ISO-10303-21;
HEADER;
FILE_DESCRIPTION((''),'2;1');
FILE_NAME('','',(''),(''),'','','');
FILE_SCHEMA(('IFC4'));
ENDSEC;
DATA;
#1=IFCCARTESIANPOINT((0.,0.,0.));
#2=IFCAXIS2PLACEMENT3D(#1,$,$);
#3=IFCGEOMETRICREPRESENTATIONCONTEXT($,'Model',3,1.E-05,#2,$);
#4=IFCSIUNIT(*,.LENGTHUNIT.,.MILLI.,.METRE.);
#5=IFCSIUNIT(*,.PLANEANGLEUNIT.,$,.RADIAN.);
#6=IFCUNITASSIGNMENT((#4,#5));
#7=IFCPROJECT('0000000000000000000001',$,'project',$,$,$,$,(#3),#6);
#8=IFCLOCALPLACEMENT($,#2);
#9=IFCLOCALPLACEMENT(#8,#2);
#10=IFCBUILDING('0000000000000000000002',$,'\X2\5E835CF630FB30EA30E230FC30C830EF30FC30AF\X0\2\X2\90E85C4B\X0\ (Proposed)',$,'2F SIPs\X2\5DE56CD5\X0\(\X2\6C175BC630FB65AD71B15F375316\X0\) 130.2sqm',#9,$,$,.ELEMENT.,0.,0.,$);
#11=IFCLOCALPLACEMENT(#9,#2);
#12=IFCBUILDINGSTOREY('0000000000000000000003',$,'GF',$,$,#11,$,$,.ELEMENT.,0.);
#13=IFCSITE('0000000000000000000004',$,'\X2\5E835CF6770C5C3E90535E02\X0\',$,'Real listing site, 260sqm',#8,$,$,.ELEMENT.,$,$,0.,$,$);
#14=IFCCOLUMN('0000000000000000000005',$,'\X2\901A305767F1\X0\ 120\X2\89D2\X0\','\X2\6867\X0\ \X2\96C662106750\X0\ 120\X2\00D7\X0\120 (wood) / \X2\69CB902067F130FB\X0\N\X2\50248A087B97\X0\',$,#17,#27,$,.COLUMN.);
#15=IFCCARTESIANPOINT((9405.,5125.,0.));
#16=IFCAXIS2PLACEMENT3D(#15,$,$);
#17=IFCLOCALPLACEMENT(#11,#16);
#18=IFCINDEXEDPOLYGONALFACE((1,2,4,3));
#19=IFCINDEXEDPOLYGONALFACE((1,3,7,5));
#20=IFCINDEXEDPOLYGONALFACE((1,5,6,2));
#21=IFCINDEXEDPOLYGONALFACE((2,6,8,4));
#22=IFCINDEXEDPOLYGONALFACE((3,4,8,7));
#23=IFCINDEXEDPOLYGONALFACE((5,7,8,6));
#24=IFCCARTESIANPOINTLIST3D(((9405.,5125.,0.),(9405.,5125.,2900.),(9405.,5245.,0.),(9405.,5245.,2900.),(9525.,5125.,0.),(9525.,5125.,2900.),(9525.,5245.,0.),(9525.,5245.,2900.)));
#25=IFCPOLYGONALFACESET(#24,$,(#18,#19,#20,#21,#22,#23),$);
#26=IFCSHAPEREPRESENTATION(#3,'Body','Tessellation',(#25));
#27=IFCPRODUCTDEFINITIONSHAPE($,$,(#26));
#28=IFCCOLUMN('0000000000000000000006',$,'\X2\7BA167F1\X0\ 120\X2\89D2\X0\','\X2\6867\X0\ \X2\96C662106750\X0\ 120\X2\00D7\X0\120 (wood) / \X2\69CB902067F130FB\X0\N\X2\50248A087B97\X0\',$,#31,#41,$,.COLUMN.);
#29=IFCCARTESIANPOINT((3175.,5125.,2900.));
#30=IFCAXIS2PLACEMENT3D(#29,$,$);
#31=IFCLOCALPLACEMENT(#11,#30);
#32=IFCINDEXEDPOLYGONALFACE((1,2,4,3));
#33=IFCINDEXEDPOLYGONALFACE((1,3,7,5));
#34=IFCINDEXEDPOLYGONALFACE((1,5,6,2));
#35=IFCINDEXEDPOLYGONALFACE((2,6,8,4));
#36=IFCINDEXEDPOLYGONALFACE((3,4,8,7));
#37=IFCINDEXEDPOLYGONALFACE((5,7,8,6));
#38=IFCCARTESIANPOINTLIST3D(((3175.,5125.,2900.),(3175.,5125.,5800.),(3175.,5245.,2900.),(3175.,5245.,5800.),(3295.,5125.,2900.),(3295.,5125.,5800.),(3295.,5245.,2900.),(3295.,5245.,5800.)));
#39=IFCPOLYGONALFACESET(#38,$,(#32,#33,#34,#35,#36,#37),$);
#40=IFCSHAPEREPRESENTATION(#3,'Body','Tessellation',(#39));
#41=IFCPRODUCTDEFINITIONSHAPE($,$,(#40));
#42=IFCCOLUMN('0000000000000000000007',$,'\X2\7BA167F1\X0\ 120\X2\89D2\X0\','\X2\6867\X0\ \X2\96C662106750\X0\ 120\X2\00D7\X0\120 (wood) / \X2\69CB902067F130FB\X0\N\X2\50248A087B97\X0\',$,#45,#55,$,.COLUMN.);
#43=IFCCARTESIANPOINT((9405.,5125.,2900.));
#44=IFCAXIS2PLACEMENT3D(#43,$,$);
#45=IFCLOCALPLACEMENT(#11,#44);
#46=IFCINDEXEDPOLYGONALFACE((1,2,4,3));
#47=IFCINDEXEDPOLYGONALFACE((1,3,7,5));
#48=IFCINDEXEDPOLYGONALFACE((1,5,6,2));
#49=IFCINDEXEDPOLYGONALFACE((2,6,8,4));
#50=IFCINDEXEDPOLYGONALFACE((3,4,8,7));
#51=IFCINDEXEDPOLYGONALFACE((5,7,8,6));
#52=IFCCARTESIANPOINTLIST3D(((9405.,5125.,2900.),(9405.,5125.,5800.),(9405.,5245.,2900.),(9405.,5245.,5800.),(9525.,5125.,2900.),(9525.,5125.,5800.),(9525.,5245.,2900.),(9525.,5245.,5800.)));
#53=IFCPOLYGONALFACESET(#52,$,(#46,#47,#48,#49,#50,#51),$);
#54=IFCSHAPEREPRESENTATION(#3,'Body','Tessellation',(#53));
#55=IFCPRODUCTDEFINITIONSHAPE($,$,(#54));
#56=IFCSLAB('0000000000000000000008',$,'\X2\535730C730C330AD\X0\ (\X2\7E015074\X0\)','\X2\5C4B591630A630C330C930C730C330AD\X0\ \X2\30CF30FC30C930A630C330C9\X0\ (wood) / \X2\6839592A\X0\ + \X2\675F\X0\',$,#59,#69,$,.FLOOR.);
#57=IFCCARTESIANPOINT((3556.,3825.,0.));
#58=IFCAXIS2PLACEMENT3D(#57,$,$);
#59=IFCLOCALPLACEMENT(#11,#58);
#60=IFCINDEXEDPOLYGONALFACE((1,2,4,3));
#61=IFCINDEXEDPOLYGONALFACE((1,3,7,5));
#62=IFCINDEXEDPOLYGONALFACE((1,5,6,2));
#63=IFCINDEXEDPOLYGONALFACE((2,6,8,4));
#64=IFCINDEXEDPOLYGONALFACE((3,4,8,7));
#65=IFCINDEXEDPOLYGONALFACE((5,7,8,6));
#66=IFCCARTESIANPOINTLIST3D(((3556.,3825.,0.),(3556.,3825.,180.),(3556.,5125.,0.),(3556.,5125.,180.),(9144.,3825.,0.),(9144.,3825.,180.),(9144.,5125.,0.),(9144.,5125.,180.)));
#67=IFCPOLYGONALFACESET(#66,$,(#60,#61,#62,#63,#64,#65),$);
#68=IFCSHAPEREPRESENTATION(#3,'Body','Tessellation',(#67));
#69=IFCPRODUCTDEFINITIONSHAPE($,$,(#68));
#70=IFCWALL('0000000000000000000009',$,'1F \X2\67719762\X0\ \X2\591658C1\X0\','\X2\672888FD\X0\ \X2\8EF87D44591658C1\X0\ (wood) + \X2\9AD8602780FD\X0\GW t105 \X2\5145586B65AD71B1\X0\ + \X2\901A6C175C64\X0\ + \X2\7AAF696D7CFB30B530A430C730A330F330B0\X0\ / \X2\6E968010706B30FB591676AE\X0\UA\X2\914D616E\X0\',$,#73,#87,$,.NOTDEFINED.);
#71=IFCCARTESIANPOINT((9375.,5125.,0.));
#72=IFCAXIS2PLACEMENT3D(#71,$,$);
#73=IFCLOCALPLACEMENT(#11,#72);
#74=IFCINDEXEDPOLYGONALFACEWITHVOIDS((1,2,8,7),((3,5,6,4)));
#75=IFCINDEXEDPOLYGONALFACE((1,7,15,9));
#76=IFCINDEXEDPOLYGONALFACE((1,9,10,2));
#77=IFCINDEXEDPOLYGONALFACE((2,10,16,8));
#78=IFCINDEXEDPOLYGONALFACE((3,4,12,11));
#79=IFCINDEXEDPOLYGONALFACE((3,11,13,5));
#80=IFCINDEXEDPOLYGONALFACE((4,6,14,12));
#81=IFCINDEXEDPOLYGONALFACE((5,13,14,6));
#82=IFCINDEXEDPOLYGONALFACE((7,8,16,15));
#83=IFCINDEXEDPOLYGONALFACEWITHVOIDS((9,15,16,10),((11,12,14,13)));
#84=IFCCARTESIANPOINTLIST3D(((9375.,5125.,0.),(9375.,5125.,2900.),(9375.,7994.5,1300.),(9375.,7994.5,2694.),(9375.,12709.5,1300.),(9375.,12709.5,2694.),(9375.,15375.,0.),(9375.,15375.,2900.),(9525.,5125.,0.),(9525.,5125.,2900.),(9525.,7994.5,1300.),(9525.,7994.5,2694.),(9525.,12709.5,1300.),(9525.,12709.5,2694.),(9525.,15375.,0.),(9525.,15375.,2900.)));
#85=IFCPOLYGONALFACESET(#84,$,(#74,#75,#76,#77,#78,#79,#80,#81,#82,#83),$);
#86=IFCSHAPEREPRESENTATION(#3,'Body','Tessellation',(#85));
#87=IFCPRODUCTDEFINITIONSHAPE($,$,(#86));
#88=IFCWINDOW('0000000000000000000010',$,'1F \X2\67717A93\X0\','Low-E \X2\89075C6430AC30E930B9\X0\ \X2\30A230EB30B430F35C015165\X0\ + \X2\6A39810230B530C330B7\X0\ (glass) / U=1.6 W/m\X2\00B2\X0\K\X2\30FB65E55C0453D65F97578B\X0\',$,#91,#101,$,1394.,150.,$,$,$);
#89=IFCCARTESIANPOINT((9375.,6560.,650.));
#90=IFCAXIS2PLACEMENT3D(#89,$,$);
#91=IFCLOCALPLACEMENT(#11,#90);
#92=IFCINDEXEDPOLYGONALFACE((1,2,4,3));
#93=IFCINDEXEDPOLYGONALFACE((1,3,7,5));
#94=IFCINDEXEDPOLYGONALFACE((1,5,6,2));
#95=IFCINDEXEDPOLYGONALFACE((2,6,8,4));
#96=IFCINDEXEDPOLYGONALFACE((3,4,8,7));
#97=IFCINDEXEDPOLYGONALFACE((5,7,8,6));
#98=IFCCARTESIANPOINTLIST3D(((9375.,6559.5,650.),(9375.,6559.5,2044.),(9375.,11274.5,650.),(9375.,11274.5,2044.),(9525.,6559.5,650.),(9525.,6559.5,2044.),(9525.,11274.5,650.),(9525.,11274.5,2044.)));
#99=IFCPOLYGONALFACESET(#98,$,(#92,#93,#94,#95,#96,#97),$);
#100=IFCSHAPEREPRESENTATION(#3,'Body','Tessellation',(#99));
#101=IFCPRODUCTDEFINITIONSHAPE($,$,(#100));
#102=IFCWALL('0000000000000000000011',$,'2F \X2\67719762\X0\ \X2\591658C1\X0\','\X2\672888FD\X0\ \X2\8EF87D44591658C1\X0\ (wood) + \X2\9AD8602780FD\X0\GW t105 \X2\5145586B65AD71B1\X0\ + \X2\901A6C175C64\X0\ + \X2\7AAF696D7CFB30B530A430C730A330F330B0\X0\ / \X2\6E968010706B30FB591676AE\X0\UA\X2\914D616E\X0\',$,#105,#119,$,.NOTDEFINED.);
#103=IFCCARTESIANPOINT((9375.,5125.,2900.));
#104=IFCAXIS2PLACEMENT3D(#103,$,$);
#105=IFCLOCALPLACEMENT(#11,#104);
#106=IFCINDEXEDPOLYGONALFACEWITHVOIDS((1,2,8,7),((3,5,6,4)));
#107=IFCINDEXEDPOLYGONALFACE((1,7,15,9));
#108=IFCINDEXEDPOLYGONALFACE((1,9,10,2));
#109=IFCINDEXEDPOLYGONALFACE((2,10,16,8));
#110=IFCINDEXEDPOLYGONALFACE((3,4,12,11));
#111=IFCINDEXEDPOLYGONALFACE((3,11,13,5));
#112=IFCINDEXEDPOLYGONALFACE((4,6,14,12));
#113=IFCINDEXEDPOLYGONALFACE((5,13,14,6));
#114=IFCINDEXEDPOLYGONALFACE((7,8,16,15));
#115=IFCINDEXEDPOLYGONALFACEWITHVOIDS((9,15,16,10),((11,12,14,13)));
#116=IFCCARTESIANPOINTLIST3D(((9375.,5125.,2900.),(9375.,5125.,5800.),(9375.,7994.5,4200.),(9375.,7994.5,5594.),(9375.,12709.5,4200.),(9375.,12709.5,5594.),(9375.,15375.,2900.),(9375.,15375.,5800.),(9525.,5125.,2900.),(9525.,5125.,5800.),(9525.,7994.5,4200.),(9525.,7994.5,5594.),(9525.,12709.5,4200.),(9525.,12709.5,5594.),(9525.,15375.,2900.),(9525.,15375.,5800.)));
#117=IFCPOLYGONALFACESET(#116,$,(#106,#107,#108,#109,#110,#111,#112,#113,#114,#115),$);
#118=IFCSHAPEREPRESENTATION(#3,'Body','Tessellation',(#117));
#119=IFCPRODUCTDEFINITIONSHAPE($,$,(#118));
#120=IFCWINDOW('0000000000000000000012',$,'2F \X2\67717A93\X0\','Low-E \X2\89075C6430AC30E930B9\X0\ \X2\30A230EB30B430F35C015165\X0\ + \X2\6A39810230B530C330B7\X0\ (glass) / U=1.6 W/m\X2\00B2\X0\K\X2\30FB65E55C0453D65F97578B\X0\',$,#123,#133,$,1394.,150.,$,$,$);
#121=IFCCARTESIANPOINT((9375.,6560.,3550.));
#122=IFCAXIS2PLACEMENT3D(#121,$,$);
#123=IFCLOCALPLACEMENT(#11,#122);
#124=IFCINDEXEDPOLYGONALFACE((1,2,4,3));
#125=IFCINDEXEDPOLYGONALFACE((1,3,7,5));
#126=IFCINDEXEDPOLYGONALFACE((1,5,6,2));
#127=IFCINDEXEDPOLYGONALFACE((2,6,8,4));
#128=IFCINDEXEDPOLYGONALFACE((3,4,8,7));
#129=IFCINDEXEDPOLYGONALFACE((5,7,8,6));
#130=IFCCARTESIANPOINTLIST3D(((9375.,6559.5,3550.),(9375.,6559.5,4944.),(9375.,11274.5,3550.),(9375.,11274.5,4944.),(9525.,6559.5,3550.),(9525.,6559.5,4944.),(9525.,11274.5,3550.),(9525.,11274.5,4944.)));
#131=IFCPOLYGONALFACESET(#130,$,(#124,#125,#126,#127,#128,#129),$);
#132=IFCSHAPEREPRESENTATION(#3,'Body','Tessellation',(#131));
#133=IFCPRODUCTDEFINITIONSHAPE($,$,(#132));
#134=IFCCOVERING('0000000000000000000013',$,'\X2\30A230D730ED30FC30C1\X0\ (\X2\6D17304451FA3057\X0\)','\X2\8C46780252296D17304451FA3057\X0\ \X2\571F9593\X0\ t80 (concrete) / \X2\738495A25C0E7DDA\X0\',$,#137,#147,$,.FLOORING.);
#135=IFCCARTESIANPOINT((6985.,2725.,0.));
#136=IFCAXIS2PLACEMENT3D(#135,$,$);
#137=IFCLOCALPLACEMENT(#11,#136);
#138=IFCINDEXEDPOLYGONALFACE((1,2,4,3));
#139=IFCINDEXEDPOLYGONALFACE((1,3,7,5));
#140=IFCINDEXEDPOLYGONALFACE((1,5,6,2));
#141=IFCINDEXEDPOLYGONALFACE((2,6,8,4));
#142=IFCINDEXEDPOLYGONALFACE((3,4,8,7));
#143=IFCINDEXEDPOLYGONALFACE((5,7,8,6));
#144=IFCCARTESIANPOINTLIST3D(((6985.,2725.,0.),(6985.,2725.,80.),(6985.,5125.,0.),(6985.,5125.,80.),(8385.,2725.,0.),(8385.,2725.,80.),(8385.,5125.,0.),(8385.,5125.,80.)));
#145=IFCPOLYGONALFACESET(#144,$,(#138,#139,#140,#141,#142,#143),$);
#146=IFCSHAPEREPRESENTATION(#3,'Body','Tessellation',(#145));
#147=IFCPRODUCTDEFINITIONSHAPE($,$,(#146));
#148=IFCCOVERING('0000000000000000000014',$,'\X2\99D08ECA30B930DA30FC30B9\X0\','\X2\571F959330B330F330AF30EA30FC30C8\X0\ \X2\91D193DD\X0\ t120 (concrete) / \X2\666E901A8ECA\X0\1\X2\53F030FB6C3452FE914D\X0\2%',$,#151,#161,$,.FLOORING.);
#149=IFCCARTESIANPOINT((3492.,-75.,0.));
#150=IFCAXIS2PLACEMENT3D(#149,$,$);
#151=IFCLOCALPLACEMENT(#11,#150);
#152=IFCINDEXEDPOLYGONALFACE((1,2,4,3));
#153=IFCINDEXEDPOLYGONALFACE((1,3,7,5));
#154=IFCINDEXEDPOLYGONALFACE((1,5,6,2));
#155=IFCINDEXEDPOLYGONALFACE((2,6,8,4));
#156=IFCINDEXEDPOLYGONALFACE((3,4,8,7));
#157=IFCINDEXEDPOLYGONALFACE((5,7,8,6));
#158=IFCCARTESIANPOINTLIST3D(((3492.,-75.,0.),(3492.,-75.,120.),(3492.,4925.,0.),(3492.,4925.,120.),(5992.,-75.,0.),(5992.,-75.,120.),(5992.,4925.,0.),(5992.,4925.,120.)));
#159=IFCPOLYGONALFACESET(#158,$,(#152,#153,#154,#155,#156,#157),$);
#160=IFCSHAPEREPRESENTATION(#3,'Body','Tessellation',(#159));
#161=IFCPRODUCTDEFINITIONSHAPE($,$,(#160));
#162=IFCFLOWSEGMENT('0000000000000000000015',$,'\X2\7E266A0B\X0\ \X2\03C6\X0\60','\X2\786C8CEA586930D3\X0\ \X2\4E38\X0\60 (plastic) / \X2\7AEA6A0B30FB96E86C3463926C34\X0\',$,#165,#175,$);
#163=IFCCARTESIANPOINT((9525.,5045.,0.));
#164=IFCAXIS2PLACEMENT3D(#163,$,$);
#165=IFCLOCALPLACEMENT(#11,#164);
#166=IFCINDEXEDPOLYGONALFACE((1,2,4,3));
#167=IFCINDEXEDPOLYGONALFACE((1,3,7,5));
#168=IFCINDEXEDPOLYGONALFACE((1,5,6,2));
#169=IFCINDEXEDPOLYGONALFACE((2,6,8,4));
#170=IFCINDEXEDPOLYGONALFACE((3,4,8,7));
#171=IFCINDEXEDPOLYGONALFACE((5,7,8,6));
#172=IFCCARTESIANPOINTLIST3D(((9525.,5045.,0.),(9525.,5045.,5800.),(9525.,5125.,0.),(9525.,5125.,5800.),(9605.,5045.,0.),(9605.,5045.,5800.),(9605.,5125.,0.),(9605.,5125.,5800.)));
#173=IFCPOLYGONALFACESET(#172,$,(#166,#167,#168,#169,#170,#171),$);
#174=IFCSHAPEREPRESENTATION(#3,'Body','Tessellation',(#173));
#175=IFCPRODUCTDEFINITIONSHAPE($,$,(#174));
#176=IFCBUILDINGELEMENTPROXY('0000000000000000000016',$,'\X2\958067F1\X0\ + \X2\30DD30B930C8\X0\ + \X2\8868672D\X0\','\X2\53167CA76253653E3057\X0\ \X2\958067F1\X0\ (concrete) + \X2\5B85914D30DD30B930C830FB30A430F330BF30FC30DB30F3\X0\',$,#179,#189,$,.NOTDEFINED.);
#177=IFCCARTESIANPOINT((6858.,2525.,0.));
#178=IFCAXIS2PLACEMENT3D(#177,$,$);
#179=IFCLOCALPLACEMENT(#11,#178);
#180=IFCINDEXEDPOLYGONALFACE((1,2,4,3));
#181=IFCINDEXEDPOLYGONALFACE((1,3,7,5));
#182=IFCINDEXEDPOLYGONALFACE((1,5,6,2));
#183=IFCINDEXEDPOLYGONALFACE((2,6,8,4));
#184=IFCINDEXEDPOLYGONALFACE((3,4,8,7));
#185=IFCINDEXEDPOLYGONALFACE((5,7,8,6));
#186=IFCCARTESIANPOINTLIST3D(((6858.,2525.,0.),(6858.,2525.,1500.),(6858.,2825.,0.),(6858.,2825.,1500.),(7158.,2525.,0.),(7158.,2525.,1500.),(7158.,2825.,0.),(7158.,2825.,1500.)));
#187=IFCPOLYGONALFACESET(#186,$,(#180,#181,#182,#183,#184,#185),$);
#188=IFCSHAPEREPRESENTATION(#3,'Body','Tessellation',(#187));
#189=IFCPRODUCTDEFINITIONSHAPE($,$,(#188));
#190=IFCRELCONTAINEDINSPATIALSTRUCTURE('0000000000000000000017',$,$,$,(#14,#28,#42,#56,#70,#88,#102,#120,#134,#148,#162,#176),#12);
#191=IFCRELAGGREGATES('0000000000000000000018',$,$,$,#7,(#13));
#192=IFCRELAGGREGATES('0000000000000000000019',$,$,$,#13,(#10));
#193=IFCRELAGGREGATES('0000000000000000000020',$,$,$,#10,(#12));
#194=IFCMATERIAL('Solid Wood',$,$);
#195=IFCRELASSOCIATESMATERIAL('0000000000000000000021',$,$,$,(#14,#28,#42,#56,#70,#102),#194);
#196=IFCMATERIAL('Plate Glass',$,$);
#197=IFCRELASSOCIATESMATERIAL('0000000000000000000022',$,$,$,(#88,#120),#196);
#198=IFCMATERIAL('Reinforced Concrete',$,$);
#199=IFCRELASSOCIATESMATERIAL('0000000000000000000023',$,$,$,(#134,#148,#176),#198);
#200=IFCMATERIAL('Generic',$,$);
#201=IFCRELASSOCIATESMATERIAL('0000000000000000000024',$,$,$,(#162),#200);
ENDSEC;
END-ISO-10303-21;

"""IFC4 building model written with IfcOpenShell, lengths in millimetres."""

from ifc_helpers import new_model, si_unit, frame, frame_2d, origin, place, context, project, spatial, rectangle, extrude, material, element, fill, save


model = new_model("IFC4")

# Units and contexts
model_context = context("Model", 3, precision=1e-05, world=origin())
ifc_project = project(units=[si_unit("LENGTHUNIT", "METRE", prefix="MILLI"), si_unit("PLANEANGLEUNIT", "RADIAN")], contexts=[model_context])

# Site, building, storey
site_placement = place(None, origin())
site = spatial("IfcSite", under=ifc_project, at=site_placement, Name="広島県尾道市", ObjectType="Real listing site, 260sqm", CompositionType="ELEMENT", RefElevation=0.0)
building_placement = place(site_placement, origin())
building = spatial("IfcBuilding", under=site, at=building_placement, Name="広島・リモートワーク2部屋 (Proposed)", ObjectType="2F SIPs工法(気密・断熱強化) 130.2sqm", CompositionType="ELEMENT", ElevationOfRefHeight=0.0, ElevationOfTerrain=0.0)
storey_placement = place(building_placement, origin())
storey = spatial("IfcBuildingStorey", under=building, at=storey_placement, Name="GF", CompositionType="ELEMENT", Elevation=0.0)

# Columns
ifc_material_1 = material(Name="Solid Wood")
column_1_placement = place(storey_placement, frame((9405.0, 5125.0, 0.0)))
element("IfcColumn", 1, at=column_1_placement, inside=storey, material=ifc_material_1, Name="通し柱 120角", Description="桧 集成材 120×120 (wood) / 構造柱・N値計算", PredefinedType="COLUMN", context=model_context, shape_type="SweptSolid", body=[
    extrude(rectangle(XDim=120.0, YDim=120.0, at=frame_2d((60.0, 60.0))), frame((9405.0, 5125.0, 0.0)), (0.0, 0.0, 1.0), 2900.0),
])
column_2_placement = place(storey_placement, frame((3175.0, 5125.0, 2900.0)))
element("IfcColumn", 2, at=column_2_placement, inside=storey, material=ifc_material_1, Name="管柱 120角", Description="桧 集成材 120×120 (wood) / 構造柱・N値計算", PredefinedType="COLUMN", context=model_context, shape_type="SweptSolid", body=[
    extrude(rectangle(XDim=120.0, YDim=120.0, at=frame_2d((60.0, 60.0))), frame((3175.0, 5125.0, 2900.0)), (0.0, 0.0, 1.0), 2900.0),
])
column_3_placement = place(storey_placement, frame((9405.0, 5125.0, 2900.0)))
element("IfcColumn", 3, at=column_3_placement, inside=storey, material=ifc_material_1, Name="管柱 120角", Description="桧 集成材 120×120 (wood) / 構造柱・N値計算", PredefinedType="COLUMN", context=model_context, shape_type="SweptSolid", body=[
    extrude(rectangle(XDim=120.0, YDim=120.0, at=frame_2d((60.0, 60.0))), frame((9405.0, 5125.0, 2900.0)), (0.0, 0.0, 1.0), 2900.0),
])

# Slab
slab_placement = place(storey_placement, frame((3556.0, 3825.0, 0.0)))
element("IfcSlab", 4, at=slab_placement, inside=storey, material=ifc_material_1, Name="南デッキ (縁側)", Description="屋外ウッドデッキ ハードウッド (wood) / 根太 + 束", PredefinedType="FLOOR", context=model_context, shape_type="SweptSolid", body=[
    extrude(rectangle(XDim=5588.0, YDim=1300.0, at=frame_2d((2794.0, 650.0))), frame((3556.0, 3825.0, 0.0)), (0.0, 0.0, 1.0), 180.0),
])

# Walls, openings, windows
wall_1_placement = place(storey_placement, frame((9375.0, 5125.0, 0.0)))
wall_1 = element("IfcWall", 5, at=wall_1_placement, inside=storey, material=ifc_material_1, Name="1F 東面 外壁", Description="木製 軸組外壁 (wood) + 高性能GW t105 充填断熱 + 通気層 + 窯業系サイディング / 準耐火・外皮UA配慮", PredefinedType="NOTDEFINED", context=model_context, shape_type="SweptSolid", body=[
    extrude(rectangle(XDim=150.0, YDim=10250.0, at=frame_2d((75.0, 5125.0))), frame((9375.0, 5125.0, 0.0)), (0.0, 0.0, 1.0), 2900.0),
])
opening_1_placement = place(storey_placement, frame((9375.0, 6560.0, 650.0)))
opening_1 = element("IfcOpeningElement", 6, at=opening_1_placement, cuts=wall_1, PredefinedType="NOTDEFINED", context=model_context, shape_type="SweptSolid", body=[
    extrude(rectangle(XDim=150.0, YDim=4715.0, at=frame_2d((75.0, 2357.0))), frame((9375.0, 6560.0, 650.0)), (0.0, 0.0, 1.0), 1394.0),
])
ifc_material_2 = material(Name="Plate Glass")
window_1_placement = place(storey_placement, frame((9375.0, 6560.0, 650.0)))
window_1 = element("IfcWindow", 7, at=window_1_placement, inside=storey, material=ifc_material_2, Name="1F 東窓", Description="Low-E 複層ガラス アルゴン封入 + 樹脂サッシ (glass) / U=1.6 W/m²K・日射取得型", OverallHeight=1394.0, OverallWidth=150.0, context=model_context, shape_type="SweptSolid", body=[
    extrude(rectangle(XDim=150.0, YDim=4715.0, at=frame_2d((75.0, 2357.0))), frame((9375.0, 6560.0, 650.0)), (0.0, 0.0, 1.0), 1394.0),
])
fill(opening_1, window_1)
wall_2_placement = place(storey_placement, frame((9375.0, 5125.0, 2900.0)))
wall_2 = element("IfcWall", 8, at=wall_2_placement, inside=storey, material=ifc_material_1, Name="2F 東面 外壁", Description="木製 軸組外壁 (wood) + 高性能GW t105 充填断熱 + 通気層 + 窯業系サイディング / 準耐火・外皮UA配慮", PredefinedType="NOTDEFINED", context=model_context, shape_type="SweptSolid", body=[
    extrude(rectangle(XDim=150.0, YDim=10250.0, at=frame_2d((75.0, 5125.0))), frame((9375.0, 5125.0, 2900.0)), (0.0, 0.0, 1.0), 2900.0),
])
opening_2_placement = place(storey_placement, frame((9375.0, 6560.0, 3550.0)))
opening_2 = element("IfcOpeningElement", 9, at=opening_2_placement, cuts=wall_2, PredefinedType="NOTDEFINED", context=model_context, shape_type="SweptSolid", body=[
    extrude(rectangle(XDim=150.0, YDim=4715.0, at=frame_2d((75.0, 2357.0))), frame((9375.0, 6560.0, 3550.0)), (0.0, 0.0, 1.0), 1394.0),
])
window_2_placement = place(storey_placement, frame((9375.0, 6560.0, 3550.0)))
window_2 = element("IfcWindow", 10, at=window_2_placement, inside=storey, material=ifc_material_2, Name="2F 東窓", Description="Low-E 複層ガラス アルゴン封入 + 樹脂サッシ (glass) / U=1.6 W/m²K・日射取得型", OverallHeight=1394.0, OverallWidth=150.0, context=model_context, shape_type="SweptSolid", body=[
    extrude(rectangle(XDim=150.0, YDim=4715.0, at=frame_2d((75.0, 2357.0))), frame((9375.0, 6560.0, 3550.0)), (0.0, 0.0, 1.0), 1394.0),
])
fill(opening_2, window_2)

# Coverings
ifc_material_3 = material(Name="Reinforced Concrete")
covering_1_placement = place(storey_placement, frame((6985.0, 2725.0, 0.0)))
element("IfcCovering", 11, at=covering_1_placement, inside=storey, material=ifc_material_3, Name="アプローチ (洗い出し)", Description="豆砂利洗い出し 土間 t80 (concrete) / 玄関導線", PredefinedType="FLOORING", context=model_context, shape_type="SweptSolid", body=[
    extrude(rectangle(XDim=1400.0, YDim=2400.0, at=frame_2d((700.0, 1200.0))), frame((6985.0, 2725.0, 0.0)), (0.0, 0.0, 1.0), 80.0),
])
covering_2_placement = place(storey_placement, frame((3492.0, -75.0, 0.0)))
element("IfcCovering", 12, at=covering_2_placement, inside=storey, material=ifc_material_3, Name="駐車スペース", Description="土間コンクリート 金鏝 t120 (concrete) / 普通車1台・水勾配2%", PredefinedType="FLOORING", context=model_context, shape_type="SweptSolid", body=[
    extrude(rectangle(XDim=2500.0, YDim=5000.0, at=frame_2d((1250.0, 2500.0))), frame((3492.0, -75.0, 0.0)), (0.0, 0.0, 1.0), 120.0),
])

# Flow segment
ifc_material_4 = material(Name="Generic")
flow_segment_placement = place(storey_placement, frame((9525.0, 5045.0, 0.0)))
element("IfcFlowSegment", 13, at=flow_segment_placement, inside=storey, material=ifc_material_4, Name="縦樋 φ60", Description="硬質塩ビ 丸60 (plastic) / 竪樋・雨水排水", context=model_context, shape_type="SweptSolid", body=[
    extrude(rectangle(XDim=80.0, YDim=80.0, at=frame_2d((40.0, 40.0))), frame((9525.0, 5045.0, 0.0)), (0.0, 0.0, 1.0), 5800.0),
])

# Building element proxy
proxy_placement = place(storey_placement, frame((6858.0, 2525.0, 0.0)))
element("IfcBuildingElementProxy", 14, at=proxy_placement, inside=storey, material=ifc_material_3, Name="門柱 + ポスト + 表札", Description="化粧打放し 門柱 (concrete) + 宅配ポスト・インターホン", PredefinedType="NOTDEFINED", context=model_context, shape_type="SweptSolid", body=[
    extrude(rectangle(XDim=300.0, YDim=300.0, at=frame_2d((150.0, 150.0))), frame((6858.0, 2525.0, 0.0)), (0.0, 0.0, 1.0), 1500.0),
])

save(model, "model.ifc")
